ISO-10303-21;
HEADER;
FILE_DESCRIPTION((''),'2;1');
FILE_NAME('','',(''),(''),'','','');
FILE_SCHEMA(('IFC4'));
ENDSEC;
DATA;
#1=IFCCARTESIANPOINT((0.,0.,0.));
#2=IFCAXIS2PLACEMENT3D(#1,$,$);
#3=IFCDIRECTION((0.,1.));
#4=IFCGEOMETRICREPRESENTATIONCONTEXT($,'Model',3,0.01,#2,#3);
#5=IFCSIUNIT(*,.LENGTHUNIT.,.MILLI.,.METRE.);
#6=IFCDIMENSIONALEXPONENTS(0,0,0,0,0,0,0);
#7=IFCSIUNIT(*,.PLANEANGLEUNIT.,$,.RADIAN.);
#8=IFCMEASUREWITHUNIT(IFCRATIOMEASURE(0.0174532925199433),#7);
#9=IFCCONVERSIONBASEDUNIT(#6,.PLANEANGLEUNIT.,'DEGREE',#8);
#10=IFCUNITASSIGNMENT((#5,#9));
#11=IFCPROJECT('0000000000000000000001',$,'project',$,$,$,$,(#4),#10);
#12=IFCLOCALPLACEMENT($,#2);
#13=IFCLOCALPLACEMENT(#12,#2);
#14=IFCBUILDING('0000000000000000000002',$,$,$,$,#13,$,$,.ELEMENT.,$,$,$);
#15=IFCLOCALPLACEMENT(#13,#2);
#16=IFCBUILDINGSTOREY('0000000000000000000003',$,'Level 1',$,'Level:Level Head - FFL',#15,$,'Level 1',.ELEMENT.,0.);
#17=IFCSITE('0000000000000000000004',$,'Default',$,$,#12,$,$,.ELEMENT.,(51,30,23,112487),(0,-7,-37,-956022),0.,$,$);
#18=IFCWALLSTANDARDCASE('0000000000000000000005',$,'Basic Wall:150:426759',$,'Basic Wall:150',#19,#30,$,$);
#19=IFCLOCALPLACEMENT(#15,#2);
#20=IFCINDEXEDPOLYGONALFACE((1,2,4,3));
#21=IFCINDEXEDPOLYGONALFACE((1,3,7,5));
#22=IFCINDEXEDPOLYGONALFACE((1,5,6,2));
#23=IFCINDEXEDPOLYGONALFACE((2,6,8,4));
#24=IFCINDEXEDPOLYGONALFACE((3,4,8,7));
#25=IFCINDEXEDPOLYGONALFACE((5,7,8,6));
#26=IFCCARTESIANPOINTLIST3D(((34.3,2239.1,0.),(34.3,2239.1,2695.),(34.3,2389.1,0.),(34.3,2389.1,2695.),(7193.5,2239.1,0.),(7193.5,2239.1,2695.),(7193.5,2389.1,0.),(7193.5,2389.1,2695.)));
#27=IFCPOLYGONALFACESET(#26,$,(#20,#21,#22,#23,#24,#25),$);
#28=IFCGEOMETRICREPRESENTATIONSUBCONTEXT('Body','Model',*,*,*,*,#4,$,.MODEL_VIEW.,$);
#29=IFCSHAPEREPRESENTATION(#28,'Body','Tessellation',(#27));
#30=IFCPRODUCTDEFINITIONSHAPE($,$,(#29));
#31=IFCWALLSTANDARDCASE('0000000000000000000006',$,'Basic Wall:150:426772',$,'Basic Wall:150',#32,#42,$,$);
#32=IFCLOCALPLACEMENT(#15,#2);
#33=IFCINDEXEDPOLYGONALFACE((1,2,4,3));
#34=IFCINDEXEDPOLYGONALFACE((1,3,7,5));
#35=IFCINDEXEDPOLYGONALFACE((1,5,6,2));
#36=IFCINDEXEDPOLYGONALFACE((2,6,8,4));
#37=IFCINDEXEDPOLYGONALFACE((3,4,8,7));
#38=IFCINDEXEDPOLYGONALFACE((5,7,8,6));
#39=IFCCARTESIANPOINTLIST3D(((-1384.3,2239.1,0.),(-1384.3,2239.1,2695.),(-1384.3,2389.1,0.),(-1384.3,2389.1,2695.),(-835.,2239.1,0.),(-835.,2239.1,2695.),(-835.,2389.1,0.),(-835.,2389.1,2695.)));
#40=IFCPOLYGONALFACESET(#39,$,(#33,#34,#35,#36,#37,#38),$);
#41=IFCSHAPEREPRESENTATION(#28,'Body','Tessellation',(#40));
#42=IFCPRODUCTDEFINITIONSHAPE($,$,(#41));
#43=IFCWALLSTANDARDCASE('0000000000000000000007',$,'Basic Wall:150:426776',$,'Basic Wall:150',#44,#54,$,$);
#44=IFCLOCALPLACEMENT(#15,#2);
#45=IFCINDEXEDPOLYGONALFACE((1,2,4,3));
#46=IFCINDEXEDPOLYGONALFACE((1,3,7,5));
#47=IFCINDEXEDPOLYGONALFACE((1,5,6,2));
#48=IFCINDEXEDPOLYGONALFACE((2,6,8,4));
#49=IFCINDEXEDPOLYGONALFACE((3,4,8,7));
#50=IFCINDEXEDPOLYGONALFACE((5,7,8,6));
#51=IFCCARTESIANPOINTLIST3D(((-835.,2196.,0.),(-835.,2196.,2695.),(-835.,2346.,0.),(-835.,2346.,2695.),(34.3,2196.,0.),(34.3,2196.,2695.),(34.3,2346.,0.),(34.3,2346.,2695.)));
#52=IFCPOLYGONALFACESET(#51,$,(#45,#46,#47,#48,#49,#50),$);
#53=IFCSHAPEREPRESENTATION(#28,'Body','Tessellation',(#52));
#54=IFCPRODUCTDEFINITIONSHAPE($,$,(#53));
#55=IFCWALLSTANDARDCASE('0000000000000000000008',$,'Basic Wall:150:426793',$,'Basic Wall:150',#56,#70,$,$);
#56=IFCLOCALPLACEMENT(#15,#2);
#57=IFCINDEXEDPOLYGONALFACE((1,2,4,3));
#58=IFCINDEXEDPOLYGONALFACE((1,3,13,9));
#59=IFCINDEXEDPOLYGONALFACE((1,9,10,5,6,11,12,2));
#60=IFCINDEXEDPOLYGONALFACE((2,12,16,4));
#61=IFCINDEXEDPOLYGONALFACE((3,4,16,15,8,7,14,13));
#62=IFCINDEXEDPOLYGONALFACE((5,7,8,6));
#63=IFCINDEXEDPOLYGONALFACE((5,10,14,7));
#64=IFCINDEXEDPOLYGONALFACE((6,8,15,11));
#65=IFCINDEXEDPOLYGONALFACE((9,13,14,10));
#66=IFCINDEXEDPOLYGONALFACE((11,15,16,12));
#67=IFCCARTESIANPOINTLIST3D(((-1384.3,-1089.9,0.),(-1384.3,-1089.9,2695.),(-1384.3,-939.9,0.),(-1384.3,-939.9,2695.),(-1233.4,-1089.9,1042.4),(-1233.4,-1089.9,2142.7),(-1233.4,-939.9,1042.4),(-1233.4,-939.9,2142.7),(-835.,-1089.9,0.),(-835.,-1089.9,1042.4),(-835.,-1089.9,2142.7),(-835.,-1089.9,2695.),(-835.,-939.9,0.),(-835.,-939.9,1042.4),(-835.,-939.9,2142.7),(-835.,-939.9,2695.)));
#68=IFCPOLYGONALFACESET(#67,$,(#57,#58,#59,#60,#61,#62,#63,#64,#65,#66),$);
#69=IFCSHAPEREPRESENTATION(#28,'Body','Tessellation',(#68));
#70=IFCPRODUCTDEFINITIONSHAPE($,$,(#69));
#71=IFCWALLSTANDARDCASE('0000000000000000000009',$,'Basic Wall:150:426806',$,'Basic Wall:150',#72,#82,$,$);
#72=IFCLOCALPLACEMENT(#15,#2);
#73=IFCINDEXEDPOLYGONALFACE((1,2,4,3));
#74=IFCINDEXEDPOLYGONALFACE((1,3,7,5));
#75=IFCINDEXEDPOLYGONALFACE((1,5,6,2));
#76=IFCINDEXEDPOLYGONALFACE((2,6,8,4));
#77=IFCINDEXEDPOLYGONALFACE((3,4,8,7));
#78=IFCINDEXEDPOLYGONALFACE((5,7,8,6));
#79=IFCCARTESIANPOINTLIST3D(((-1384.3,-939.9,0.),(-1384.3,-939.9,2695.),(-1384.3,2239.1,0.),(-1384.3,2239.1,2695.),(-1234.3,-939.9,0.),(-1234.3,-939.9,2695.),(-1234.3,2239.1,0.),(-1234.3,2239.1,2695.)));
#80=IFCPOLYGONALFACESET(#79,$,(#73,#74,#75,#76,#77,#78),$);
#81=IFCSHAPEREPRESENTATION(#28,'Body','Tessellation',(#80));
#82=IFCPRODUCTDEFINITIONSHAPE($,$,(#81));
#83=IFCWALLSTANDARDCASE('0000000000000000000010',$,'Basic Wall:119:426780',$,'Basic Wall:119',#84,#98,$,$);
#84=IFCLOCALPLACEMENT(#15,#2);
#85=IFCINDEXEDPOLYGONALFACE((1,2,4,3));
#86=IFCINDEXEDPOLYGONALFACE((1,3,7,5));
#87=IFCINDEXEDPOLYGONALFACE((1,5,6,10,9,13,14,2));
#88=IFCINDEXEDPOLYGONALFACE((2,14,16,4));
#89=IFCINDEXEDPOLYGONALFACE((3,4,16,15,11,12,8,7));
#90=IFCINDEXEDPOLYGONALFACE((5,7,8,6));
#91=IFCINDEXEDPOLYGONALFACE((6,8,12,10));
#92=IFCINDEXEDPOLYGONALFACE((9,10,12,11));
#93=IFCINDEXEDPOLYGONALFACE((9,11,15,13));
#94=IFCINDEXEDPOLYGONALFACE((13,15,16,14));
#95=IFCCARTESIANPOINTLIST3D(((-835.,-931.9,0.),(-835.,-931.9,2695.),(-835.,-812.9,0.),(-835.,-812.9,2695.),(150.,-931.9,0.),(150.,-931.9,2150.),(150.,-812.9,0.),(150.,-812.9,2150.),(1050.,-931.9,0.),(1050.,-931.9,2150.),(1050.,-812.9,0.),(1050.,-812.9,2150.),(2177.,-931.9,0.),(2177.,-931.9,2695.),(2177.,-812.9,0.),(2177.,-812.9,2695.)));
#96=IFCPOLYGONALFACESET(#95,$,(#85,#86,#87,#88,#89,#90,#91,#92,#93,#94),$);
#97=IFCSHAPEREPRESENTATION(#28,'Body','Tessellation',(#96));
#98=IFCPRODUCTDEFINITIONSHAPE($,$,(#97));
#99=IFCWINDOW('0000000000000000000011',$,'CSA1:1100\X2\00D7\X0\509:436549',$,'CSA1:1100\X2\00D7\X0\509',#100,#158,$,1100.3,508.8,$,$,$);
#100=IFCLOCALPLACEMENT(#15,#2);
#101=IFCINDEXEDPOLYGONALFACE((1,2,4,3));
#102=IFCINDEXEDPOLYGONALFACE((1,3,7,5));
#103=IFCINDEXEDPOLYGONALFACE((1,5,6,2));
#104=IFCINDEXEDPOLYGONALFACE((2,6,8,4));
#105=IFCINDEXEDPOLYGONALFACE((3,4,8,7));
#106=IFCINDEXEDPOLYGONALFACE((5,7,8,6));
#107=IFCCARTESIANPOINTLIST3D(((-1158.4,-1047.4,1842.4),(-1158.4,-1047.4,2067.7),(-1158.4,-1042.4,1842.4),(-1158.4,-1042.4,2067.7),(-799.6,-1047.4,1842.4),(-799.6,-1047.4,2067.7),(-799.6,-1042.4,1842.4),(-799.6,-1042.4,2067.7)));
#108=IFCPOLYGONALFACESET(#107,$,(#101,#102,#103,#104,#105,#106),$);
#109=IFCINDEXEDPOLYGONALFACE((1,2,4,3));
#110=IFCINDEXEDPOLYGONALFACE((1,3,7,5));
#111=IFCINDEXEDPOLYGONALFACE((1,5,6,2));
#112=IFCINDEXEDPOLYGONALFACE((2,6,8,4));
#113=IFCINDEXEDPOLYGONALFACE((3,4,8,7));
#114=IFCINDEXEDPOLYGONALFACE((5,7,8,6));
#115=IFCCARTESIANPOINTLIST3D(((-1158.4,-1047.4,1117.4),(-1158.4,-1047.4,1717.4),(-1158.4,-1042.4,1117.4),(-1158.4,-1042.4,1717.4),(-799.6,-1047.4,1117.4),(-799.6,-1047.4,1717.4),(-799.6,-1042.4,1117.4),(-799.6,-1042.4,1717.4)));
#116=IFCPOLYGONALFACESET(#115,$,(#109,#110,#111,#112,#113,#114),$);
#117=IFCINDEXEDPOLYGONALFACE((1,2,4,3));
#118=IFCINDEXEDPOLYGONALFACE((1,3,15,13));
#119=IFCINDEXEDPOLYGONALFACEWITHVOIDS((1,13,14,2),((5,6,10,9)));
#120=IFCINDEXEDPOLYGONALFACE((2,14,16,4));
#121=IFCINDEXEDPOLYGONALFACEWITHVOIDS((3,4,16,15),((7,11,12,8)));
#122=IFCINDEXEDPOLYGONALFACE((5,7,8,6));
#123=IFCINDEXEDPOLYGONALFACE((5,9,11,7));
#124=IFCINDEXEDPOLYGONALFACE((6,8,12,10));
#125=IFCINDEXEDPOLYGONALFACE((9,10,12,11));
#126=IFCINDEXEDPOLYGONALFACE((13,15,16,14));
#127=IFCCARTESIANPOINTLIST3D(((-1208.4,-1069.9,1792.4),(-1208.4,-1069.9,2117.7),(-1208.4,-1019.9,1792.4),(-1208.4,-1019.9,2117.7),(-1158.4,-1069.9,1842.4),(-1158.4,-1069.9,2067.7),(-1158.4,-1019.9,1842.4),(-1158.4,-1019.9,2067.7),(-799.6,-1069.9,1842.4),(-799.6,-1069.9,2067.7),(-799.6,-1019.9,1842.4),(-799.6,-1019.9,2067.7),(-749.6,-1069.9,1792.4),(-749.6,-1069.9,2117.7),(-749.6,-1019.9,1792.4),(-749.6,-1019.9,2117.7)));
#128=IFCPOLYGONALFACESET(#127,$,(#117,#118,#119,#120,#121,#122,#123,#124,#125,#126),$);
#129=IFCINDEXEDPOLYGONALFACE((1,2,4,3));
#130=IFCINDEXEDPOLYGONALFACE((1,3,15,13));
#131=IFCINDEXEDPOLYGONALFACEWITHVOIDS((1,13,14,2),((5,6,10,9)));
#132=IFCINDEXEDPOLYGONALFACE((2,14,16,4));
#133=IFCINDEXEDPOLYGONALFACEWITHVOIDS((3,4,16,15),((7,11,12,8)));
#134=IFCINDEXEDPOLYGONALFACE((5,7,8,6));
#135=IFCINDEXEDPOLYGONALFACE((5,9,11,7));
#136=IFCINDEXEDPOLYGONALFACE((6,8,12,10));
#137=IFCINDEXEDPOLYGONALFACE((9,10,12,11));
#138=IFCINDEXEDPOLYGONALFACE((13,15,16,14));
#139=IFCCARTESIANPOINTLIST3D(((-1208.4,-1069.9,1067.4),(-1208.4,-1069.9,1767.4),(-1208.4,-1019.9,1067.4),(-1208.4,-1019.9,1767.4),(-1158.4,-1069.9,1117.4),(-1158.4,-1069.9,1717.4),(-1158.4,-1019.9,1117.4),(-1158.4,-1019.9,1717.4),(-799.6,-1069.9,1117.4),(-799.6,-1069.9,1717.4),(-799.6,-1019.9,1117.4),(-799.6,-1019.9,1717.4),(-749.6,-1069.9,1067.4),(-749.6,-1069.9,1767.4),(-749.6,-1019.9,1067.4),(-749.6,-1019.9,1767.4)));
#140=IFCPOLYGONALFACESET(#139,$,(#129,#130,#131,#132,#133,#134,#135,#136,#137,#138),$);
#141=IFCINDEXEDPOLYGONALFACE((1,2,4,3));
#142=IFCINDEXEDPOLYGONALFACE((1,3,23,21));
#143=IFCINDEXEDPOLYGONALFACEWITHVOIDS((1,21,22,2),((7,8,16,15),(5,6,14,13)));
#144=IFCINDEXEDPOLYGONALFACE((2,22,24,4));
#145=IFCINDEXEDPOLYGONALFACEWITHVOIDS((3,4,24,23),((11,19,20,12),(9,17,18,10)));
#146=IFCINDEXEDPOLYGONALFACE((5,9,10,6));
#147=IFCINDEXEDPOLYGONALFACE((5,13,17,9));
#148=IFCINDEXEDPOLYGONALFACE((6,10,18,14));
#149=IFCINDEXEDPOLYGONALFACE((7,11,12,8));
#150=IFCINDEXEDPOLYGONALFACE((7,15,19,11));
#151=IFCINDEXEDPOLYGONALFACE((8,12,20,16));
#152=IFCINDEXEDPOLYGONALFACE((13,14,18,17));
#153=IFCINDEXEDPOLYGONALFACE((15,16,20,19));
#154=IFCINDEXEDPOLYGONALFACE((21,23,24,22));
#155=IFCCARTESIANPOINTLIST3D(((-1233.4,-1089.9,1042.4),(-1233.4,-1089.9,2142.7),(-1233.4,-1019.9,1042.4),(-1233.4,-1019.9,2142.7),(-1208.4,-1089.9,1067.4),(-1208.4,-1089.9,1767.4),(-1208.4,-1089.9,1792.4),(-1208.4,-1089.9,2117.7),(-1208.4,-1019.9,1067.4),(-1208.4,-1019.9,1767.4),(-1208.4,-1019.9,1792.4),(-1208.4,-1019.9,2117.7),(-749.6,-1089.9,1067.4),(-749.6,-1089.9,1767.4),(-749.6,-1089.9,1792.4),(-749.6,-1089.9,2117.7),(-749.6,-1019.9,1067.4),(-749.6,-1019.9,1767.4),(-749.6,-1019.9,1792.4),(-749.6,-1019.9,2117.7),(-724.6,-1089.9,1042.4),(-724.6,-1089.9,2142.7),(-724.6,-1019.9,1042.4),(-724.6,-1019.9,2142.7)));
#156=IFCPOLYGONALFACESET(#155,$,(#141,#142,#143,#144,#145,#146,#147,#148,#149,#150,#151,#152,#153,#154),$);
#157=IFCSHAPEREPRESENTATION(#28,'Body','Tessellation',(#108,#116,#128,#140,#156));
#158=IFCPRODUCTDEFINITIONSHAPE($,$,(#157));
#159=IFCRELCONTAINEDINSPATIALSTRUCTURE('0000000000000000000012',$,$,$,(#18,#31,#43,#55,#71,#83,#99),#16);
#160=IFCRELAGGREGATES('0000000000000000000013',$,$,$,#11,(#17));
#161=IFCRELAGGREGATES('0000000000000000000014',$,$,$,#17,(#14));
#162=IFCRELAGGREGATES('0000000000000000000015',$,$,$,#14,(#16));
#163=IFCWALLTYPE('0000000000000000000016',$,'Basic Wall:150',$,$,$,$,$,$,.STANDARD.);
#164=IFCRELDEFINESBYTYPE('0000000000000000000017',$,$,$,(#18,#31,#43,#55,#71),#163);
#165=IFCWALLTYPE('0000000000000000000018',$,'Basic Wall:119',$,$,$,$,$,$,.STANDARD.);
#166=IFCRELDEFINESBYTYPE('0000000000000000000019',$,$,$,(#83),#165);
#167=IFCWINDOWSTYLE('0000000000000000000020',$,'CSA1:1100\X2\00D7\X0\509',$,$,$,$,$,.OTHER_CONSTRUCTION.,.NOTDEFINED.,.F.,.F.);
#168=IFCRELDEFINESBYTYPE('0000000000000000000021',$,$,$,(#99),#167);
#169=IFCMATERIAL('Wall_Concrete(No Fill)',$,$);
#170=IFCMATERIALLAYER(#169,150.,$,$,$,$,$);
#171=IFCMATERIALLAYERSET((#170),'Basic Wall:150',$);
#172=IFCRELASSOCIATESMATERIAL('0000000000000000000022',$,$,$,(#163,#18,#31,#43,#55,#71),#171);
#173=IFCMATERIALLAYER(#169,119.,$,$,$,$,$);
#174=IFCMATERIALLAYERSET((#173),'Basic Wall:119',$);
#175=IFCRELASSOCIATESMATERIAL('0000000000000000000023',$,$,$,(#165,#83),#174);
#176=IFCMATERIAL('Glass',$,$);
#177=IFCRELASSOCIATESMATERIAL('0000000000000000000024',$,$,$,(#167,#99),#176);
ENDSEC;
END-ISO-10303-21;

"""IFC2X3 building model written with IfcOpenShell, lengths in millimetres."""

from ifc_helpers import new_model, entity, si_unit, converted_unit, direction, frame, frame_2d, origin, place, context, subcontext, project, spatial, polyline, rectangle, outline, extrude, source, transform, mapped, material, layer, layer_set, layer_usage, type_object, type_shapes, element, save


model = new_model("IFC2X3")

# Units and contexts
model_context = context("Model", 3, precision=0.01, world=origin(), true_north=direction((0.0, 1.0)))
body_context = subcontext(model_context, "Body", "Model", "MODEL_VIEW")
ifc_project = project(units=[si_unit("LENGTHUNIT", "METRE", prefix="MILLI"), converted_unit("PLANEANGLEUNIT", "DEGREE", entity("IfcRatioMeasure", 0.0174532925199433), si_unit("PLANEANGLEUNIT", "RADIAN"), dimensions=[0, 0, 0, 0, 0, 0, 0])], contexts=[model_context])

# Site, building, storey
site_placement = place(None, origin())
site = spatial("IfcSite", under=ifc_project, at=site_placement, Name="Default", CompositionType="ELEMENT", RefLatitude=(51, 30, 23, 112487), RefLongitude=(0, -7, -37, -956022), RefElevation=0.0)
building_placement = place(site_placement, origin())
building = spatial("IfcBuilding", under=site, at=building_placement, CompositionType="ELEMENT")
storey_placement = place(building_placement, origin())
storey = spatial("IfcBuildingStorey", under=building, at=storey_placement, Name="Level 1", ObjectType="Level:Level Head - FFL", LongName="Level 1", CompositionType="ELEMENT", Elevation=0.0)

# Walls
ifc_material_1 = material(Name="Wall_Concrete(No Fill)")
ifc_layer_1 = layer(ifc_material_1, 150.0)
ifc_layer_set_1 = layer_set([ifc_layer_1], Name="Basic Wall:150")
ifc_layer_usage_1 = layer_usage(ifc_layer_set_1, "AXIS2", "NEGATIVE", 75.0)
wall_type_1 = type_object("IfcWallType", Name="Basic Wall:150", PredefinedType="STANDARD", material=ifc_layer_set_1)
wall_1_placement = place(storey_placement, frame((34.3, 2314.1, 0.0)))
element("IfcWallStandardCase", 1, at=wall_1_placement, inside=storey, type_object=wall_type_1, material=ifc_layer_usage_1, Name="Basic Wall:150:426759", ObjectType="Basic Wall:150", context=body_context, shape_type="SweptSolid", body=[
    extrude(rectangle(XDim=7159.2, YDim=150.0, at=frame_2d((3579.6, 0.0), x_axis=(-1.0, 0.0))), origin(), (0.0, 0.0, 1.0), 2695.0),
])
ifc_layer_usage_2 = layer_usage(ifc_layer_set_1, "AXIS2", "NEGATIVE", 75.0)
wall_2_placement = place(storey_placement, frame((-1384.3, 2314.1, 0.0)))
element("IfcWallStandardCase", 2, at=wall_2_placement, inside=storey, type_object=wall_type_1, material=ifc_layer_usage_2, Name="Basic Wall:150:426772", ObjectType="Basic Wall:150", context=body_context, shape_type="SweptSolid", body=[
    extrude(rectangle(XDim=549.3, YDim=150.0, at=frame_2d((274.6, 0.0), x_axis=(-1.0, 0.0))), origin(), (0.0, 0.0, 1.0), 2695.0),
])
ifc_layer_usage_3 = layer_usage(ifc_layer_set_1, "AXIS2", "NEGATIVE", 75.0)
wall_3_placement = place(storey_placement, frame((-835.0, 2271.0, 0.0)))
element("IfcWallStandardCase", 3, at=wall_3_placement, inside=storey, type_object=wall_type_1, material=ifc_layer_usage_3, Name="Basic Wall:150:426776", ObjectType="Basic Wall:150", context=body_context, shape_type="SweptSolid", body=[
    extrude(rectangle(XDim=869.3, YDim=150.0, at=frame_2d((434.6, 0.0), x_axis=(-1.0, 0.0))), origin(), (0.0, 0.0, 1.0), 2695.0),
])

# Wall, opening
ifc_layer_usage_4 = layer_usage(ifc_layer_set_1, "AXIS2", "NEGATIVE", 75.0)
wall_4_placement = place(storey_placement, frame((-1384.3, -1014.9, 0.0)))
wall_4 = element("IfcWallStandardCase", 4, at=wall_4_placement, inside=storey, type_object=wall_type_1, material=ifc_layer_usage_4, Name="Basic Wall:150:426793", ObjectType="Basic Wall:150", context=body_context, shape_type="SweptSolid", body=[
    extrude(rectangle(XDim=549.3, YDim=150.0, at=frame_2d((274.6, 0.0), x_axis=(-1.0, 0.0))), origin(), (0.0, 0.0, 1.0), 2695.0),
])
opening_1_placement = place(wall_4_placement, origin())
element("IfcOpeningElement", 5, at=opening_1_placement, cuts=wall_4, ObjectType="Opening", context=body_context, shape_type="SweptSolid", body=[
    extrude(rectangle(XDim=1100.3, YDim=508.8, at=frame_2d((0.0, 0.0), x_axis=(1.0, 0.0))), frame((405.3, -75.0, 1592.6), z_axis=(0.0, 1.0, 0.0), x_axis=(0.0, 0.0, -1.0)), (0.0, 0.0, 1.0), 150.0),
])

# Wall
ifc_layer_usage_5 = layer_usage(ifc_layer_set_1, "AXIS2", "NEGATIVE", 75.0)
wall_5_placement = place(storey_placement, frame((-1309.3, -939.9, 0.0), z_axis=(0.0, 0.0, 1.0), x_axis=(0.0, 1.0, 0.0)))
element("IfcWallStandardCase", 6, at=wall_5_placement, inside=storey, type_object=wall_type_1, material=ifc_layer_usage_5, Name="Basic Wall:150:426806", ObjectType="Basic Wall:150", context=body_context, shape_type="SweptSolid", body=[
    extrude(rectangle(XDim=3179.0, YDim=150.0, at=frame_2d((1589.5, 0.0), x_axis=(-1.0, 0.0))), origin(), (0.0, 0.0, 1.0), 2695.0),
])

# Wall, opening
ifc_layer_2 = layer(ifc_material_1, 119.0)
ifc_layer_set_2 = layer_set([ifc_layer_2], Name="Basic Wall:119")
ifc_layer_usage_6 = layer_usage(ifc_layer_set_2, "AXIS2", "NEGATIVE", 59.5)
wall_type_2 = type_object("IfcWallType", Name="Basic Wall:119", PredefinedType="STANDARD", material=ifc_layer_set_2)
wall_6_placement = place(storey_placement, frame((-835.0, -872.4, 0.0)))
wall_6 = element("IfcWallStandardCase", 7, at=wall_6_placement, inside=storey, type_object=wall_type_2, material=ifc_layer_usage_6, Name="Basic Wall:119:426780", ObjectType="Basic Wall:119", context=body_context, shape_type="SweptSolid", body=[
    extrude(rectangle(XDim=3012.0, YDim=119.0, at=frame_2d((1506.0, 0.0), x_axis=(-1.0, 0.0))), origin(), (0.0, 0.0, 1.0), 2695.0),
])
opening_2_placement = place(wall_6_placement, origin())
element("IfcOpeningElement", 8, at=opening_2_placement, cuts=wall_6, ObjectType="Opening", context=body_context, shape_type="SweptSolid", body=[
    extrude(rectangle(XDim=2150.0, YDim=900.0, at=frame_2d((0.0, 0.0), x_axis=(1.0, 0.0))), frame((1435.0, -59.5, 1075.0), z_axis=(0.0, 1.0, 0.0), x_axis=(0.0, 0.0, -1.0)), (0.0, 0.0, 1.0), 119.0),
])

# Window
ifc_material_2 = material(Name="Glass")
window_style = type_object("IfcWindowStyle", Name="CSA1:1100×509", ConstructionType="OTHER_CONSTRUCTION", OperationType="NOTDEFINED", ParameterTakesPrecedence=False, Sizeable=False, material=ifc_material_2)
shared_shape = source(origin(), body_context, "Body", "SweptSolid", [
    extrude(rectangle(XDim=5.0, YDim=358.8, at=frame_2d((0.0, 0.0), x_axis=(1.0, 0.0))), frame((254.4, 45.0, 800.0), z_axis=(0.0, 0.0, 1.0), x_axis=(0.0, 1.0, 0.0)), (0.0, 0.0, 1.0), 225.3),
    extrude(rectangle(XDim=5.0, YDim=358.8, at=frame_2d((0.0, 0.0), x_axis=(1.0, 0.0))), frame((254.4, 45.0, 75.0), z_axis=(0.0, 0.0, 1.0), x_axis=(0.0, 1.0, 0.0)), (0.0, 0.0, 1.0), 600.0),
    extrude(outline(polyline([(-229.4, -162.6), (229.4, -162.6), (229.4, 162.6), (-229.4, 162.6), (-229.4, -162.6)]), holes=[polyline([(-179.4, -112.6), (-179.4, 112.6), (179.4, 112.6), (179.4, -112.6), (-179.4, -112.6)])]), frame((254.4, 20.0, 912.6), z_axis=(0.0, 1.0, 0.0), x_axis=(1.0, 0.0, 0.0)), (0.0, 0.0, 1.0), 50.0),
    extrude(outline(polyline([(-229.4, -350.0), (229.4, -350.0), (229.4, 350.0), (-229.4, 350.0), (-229.4, -350.0)]), holes=[polyline([(-179.4, -300.0), (-179.4, 300.0), (179.4, 300.0), (179.4, -300.0), (-179.4, -300.0)])]), frame((254.4, 20.0, 375.0), z_axis=(0.0, 1.0, 0.0), x_axis=(1.0, 0.0, 0.0)), (0.0, 0.0, 1.0), 50.0),
    extrude(outline(polyline([(-254.4, -550.1), (254.4, -550.1), (254.4, 550.1), (-254.4, 550.1), (-254.4, -550.1)]), holes=[polyline([(-229.4, -525.1), (-229.4, -199.9), (229.4, -199.9), (229.4, -525.1), (-229.4, -525.1)]), polyline([(-229.4, -174.9), (-229.4, 525.1), (229.4, 525.1), (229.4, -174.9), (-229.4, -174.9)])]), frame((254.4, 0.0, 550.1), z_axis=(0.0, 1.0, 0.0), x_axis=(1.0, 0.0, 0.0)), (0.0, 0.0, 1.0), 70.0),
])
type_shapes(window_style, [shared_shape])
window_placement = place(storey_placement, frame((-1233.4, -1089.9, 1042.4)))
element("IfcWindow", 9, at=window_placement, inside=storey, type_object=window_style, material=ifc_material_2, Name="CSA1:1100×509:436549", ObjectType="CSA1:1100×509", OverallHeight=1100.3, OverallWidth=508.8, context=body_context, shape_type="MappedRepresentation", body=[
    mapped(shared_shape, transform((0.0, 0.0, 0.0), scale=1.0)),
])

save(model, "model.ifc")
